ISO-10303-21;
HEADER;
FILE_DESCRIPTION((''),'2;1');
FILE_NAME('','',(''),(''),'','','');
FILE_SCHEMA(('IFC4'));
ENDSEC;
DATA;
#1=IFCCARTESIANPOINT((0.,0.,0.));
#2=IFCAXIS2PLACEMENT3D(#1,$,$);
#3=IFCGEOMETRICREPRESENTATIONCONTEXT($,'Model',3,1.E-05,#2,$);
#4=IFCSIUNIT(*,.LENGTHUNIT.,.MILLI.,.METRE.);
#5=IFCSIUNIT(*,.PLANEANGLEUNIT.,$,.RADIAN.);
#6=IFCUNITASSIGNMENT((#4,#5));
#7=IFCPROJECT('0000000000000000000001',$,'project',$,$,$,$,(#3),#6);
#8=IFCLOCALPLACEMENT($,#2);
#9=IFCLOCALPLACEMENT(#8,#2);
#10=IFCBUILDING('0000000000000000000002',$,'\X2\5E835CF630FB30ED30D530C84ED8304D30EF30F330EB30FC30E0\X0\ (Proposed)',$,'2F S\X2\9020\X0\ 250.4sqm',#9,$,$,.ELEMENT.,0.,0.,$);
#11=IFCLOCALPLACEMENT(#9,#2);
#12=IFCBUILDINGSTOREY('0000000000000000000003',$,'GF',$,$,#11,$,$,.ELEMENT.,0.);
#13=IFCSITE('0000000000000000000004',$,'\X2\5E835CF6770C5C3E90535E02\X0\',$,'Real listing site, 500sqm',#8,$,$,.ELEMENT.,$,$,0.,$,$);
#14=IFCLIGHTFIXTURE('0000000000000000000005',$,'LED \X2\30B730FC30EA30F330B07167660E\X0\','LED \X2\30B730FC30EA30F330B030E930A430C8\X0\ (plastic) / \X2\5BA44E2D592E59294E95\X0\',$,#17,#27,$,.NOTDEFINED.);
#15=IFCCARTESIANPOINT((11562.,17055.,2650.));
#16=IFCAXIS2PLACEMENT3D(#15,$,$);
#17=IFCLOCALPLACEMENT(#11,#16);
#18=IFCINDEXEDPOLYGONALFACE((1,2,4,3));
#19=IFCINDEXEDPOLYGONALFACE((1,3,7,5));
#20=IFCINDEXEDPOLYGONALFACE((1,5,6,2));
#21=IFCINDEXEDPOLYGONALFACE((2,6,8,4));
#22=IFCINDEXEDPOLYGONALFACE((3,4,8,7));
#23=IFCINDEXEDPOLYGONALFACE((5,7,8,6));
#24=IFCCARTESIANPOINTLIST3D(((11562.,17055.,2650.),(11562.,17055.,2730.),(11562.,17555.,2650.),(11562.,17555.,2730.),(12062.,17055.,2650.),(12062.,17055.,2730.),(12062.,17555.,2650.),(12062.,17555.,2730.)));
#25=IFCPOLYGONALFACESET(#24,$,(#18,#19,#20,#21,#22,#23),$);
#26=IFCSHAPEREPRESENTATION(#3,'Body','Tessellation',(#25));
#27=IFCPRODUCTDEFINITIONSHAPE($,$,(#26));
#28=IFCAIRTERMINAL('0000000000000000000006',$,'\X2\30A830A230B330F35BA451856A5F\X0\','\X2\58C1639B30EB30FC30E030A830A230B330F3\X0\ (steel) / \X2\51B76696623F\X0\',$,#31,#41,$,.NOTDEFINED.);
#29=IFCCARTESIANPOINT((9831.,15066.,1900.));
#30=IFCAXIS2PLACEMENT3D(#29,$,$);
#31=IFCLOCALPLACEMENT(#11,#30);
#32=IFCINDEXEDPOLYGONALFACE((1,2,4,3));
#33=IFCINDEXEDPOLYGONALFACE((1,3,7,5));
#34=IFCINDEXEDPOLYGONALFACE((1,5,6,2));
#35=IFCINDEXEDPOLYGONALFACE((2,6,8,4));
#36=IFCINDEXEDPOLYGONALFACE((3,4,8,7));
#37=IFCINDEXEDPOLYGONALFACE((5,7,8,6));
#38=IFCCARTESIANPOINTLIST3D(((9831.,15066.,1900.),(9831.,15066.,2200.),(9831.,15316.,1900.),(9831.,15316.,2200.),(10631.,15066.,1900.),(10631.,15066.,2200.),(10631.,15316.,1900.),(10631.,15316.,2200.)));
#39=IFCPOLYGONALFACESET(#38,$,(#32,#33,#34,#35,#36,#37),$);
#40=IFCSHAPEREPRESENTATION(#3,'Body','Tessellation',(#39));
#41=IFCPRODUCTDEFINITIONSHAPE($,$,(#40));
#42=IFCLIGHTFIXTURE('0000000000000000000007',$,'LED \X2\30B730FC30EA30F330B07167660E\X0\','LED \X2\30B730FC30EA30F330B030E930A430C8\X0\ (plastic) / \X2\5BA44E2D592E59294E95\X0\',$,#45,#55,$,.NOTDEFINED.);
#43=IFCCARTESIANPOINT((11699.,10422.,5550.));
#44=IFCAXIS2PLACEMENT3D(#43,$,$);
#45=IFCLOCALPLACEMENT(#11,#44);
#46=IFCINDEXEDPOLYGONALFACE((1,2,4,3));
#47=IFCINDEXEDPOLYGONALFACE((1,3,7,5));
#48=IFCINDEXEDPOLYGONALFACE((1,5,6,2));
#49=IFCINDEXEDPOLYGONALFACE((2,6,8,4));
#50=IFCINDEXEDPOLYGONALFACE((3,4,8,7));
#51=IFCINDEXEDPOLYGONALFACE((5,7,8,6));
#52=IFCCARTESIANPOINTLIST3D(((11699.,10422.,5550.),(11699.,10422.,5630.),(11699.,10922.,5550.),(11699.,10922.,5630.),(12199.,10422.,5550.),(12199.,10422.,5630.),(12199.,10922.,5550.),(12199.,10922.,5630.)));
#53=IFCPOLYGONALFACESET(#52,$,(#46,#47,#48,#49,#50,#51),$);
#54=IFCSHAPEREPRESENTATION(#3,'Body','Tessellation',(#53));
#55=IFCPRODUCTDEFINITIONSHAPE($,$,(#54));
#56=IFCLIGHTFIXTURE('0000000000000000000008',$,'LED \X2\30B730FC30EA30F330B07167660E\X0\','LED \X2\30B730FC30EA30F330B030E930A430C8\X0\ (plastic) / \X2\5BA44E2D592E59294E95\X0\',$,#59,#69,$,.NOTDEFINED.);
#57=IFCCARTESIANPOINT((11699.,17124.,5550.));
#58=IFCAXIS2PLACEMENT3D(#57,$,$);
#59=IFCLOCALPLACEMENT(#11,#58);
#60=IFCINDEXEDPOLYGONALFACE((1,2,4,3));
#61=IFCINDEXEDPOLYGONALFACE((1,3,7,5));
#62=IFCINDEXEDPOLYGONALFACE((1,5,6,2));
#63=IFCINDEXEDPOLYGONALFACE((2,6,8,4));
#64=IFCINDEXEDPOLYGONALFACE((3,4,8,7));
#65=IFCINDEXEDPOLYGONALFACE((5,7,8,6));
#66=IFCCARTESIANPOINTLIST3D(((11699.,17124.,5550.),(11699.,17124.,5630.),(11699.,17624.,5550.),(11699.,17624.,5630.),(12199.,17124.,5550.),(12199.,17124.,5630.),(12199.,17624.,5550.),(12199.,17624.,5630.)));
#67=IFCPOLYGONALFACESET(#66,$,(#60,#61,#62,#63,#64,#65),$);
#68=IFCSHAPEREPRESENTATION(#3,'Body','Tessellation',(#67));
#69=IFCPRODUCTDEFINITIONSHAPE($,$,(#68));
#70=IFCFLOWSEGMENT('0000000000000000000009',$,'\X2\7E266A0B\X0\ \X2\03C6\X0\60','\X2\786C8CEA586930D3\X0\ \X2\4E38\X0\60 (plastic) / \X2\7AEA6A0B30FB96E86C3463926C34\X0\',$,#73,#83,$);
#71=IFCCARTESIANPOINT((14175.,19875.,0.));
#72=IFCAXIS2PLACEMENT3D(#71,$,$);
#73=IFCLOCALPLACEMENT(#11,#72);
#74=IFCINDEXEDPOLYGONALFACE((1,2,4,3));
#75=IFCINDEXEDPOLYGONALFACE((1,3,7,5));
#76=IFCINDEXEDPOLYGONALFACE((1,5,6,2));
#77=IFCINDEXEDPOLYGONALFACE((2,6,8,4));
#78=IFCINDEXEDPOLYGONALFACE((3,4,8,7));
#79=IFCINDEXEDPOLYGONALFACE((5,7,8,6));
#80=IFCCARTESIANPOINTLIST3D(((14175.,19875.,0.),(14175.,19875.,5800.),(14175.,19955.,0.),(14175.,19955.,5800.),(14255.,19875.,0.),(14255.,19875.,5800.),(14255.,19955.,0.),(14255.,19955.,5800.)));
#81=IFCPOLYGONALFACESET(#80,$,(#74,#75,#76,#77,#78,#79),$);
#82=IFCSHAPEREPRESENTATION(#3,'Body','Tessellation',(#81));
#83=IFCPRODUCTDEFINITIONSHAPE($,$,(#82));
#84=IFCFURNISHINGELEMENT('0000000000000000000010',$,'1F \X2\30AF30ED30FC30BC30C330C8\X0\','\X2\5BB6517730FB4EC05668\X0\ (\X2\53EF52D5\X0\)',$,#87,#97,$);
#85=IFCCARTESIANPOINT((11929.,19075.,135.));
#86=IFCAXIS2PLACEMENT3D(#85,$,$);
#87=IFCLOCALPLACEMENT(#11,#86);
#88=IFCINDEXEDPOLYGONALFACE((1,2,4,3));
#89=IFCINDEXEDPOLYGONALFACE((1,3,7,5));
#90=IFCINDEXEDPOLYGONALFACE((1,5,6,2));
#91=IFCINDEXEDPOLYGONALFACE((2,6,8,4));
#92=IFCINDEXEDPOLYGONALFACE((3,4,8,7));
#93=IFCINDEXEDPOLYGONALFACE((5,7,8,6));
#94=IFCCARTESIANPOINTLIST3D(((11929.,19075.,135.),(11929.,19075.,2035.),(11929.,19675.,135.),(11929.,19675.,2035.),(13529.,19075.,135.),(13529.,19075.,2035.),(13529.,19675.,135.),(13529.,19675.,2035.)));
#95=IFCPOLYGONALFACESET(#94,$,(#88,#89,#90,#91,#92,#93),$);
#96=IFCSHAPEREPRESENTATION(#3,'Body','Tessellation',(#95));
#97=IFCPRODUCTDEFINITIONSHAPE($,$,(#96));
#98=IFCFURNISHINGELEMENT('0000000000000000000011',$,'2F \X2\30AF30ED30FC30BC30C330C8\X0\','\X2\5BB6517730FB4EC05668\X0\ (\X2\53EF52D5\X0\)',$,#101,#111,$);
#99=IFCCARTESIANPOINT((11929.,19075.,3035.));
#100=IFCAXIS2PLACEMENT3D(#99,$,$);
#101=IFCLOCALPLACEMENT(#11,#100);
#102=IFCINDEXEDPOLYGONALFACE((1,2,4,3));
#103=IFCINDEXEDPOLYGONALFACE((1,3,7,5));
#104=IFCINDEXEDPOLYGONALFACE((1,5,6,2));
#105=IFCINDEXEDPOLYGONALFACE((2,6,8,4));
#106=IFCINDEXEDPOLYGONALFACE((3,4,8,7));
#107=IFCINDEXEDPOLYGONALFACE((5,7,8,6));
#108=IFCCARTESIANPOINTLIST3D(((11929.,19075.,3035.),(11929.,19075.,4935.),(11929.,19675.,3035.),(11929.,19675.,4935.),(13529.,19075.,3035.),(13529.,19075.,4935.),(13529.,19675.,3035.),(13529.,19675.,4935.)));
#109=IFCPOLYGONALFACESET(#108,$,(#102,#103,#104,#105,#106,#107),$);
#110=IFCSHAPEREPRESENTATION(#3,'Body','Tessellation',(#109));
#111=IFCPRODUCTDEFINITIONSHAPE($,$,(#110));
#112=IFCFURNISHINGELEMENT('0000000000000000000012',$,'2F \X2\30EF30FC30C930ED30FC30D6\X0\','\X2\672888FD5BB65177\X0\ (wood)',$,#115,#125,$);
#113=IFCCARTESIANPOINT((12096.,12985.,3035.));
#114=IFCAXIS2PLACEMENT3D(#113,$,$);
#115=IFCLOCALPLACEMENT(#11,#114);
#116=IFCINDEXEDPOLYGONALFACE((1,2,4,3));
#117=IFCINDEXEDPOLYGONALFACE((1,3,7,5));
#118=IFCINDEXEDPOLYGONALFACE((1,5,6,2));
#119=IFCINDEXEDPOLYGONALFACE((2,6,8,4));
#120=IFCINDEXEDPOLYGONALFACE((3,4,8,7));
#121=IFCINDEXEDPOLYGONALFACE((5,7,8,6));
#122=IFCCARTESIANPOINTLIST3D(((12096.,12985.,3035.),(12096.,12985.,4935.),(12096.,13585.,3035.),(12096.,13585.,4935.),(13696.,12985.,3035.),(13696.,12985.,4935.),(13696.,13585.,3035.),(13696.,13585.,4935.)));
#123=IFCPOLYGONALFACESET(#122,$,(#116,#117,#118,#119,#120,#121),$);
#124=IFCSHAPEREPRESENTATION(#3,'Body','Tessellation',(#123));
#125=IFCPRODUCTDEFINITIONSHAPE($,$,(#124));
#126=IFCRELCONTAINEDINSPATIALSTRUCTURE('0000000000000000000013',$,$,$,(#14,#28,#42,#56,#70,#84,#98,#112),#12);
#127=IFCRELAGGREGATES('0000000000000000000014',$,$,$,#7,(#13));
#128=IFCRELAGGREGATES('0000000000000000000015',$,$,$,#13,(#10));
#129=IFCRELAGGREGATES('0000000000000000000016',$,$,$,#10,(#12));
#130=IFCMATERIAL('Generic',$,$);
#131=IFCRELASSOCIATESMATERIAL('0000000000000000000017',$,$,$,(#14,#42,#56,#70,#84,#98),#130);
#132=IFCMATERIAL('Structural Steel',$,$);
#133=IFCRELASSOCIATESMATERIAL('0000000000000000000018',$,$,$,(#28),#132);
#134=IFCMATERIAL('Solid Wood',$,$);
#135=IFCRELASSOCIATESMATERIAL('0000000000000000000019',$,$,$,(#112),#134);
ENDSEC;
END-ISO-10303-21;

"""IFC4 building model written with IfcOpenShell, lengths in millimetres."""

from ifc_helpers import new_model, si_unit, frame, frame_2d, origin, place, context, project, spatial, rectangle, extrude, material, element, save


model = new_model("IFC4")

# Units and contexts
model_context = context("Model", 3, precision=1e-05, world=origin())
ifc_project = project(units=[si_unit("LENGTHUNIT", "METRE", prefix="MILLI"), si_unit("PLANEANGLEUNIT", "RADIAN")], contexts=[model_context])

# Site, building, storey
site_placement = place(None, origin())
site = spatial("IfcSite", under=ifc_project, at=site_placement, Name="広島県尾道市", ObjectType="Real listing site, 500sqm", CompositionType="ELEMENT", RefElevation=0.0)
building_placement = place(site_placement, origin())
building = spatial("IfcBuilding", under=site, at=building_placement, Name="広島・ロフト付きワンルーム (Proposed)", ObjectType="2F S造 250.4sqm", CompositionType="ELEMENT", ElevationOfRefHeight=0.0, ElevationOfTerrain=0.0)
storey_placement = place(building_placement, origin())
storey = spatial("IfcBuildingStorey", under=building, at=storey_placement, Name="GF", CompositionType="ELEMENT", Elevation=0.0)

# Shared definitions
ifc_material_1 = material(Name="Solid Wood")

# Shared definitions
ifc_material_2 = material(Name="Structural Steel")

# Shared definitions
ifc_material_3 = material(Name="Generic")

# Light fixture
light_fixture_1_placement = place(storey_placement, frame((11562.0, 17055.0, 2650.0)))
element("IfcLightFixture", 1, at=light_fixture_1_placement, inside=storey, material=ifc_material_3, Name="LED シーリング照明", Description="LED シーリングライト (plastic) / 室中央天井", PredefinedType="NOTDEFINED", context=model_context, shape_type="SweptSolid", body=[
    extrude(rectangle(XDim=500.0, YDim=500.0, at=frame_2d((250.0, 250.0))), frame((11562.0, 17055.0, 2650.0)), (0.0, 0.0, 1.0), 80.0),
])

# Air terminal
air_terminal_placement = place(storey_placement, frame((9831.0, 15066.0, 1900.0)))
element("IfcAirTerminal", 2, at=air_terminal_placement, inside=storey, material=ifc_material_2, Name="エアコン室内機", Description="壁掛ルームエアコン (steel) / 冷暖房", PredefinedType="NOTDEFINED", context=model_context, shape_type="SweptSolid", body=[
    extrude(rectangle(XDim=800.0, YDim=250.0, at=frame_2d((400.0, 125.0))), frame((9831.0, 15066.0, 1900.0)), (0.0, 0.0, 1.0), 300.0),
])

# Light fixtures
light_fixture_2_placement = place(storey_placement, frame((11699.0, 10422.0, 5550.0)))
element("IfcLightFixture", 3, at=light_fixture_2_placement, inside=storey, material=ifc_material_3, Name="LED シーリング照明", Description="LED シーリングライト (plastic) / 室中央天井", PredefinedType="NOTDEFINED", context=model_context, shape_type="SweptSolid", body=[
    extrude(rectangle(XDim=500.0, YDim=500.0, at=frame_2d((250.0, 250.0))), frame((11699.0, 10422.0, 5550.0)), (0.0, 0.0, 1.0), 80.0),
])
light_fixture_3_placement = place(storey_placement, frame((11699.0, 17124.0, 5550.0)))
element("IfcLightFixture", 4, at=light_fixture_3_placement, inside=storey, material=ifc_material_3, Name="LED シーリング照明", Description="LED シーリングライト (plastic) / 室中央天井", PredefinedType="NOTDEFINED", context=model_context, shape_type="SweptSolid", body=[
    extrude(rectangle(XDim=500.0, YDim=500.0, at=frame_2d((250.0, 250.0))), frame((11699.0, 17124.0, 5550.0)), (0.0, 0.0, 1.0), 80.0),
])

# Flow segment
flow_segment_placement = place(storey_placement, frame((14175.0, 19875.0, 0.0)))
element("IfcFlowSegment", 5, at=flow_segment_placement, inside=storey, material=ifc_material_3, Name="縦樋 φ60", Description="硬質塩ビ 丸60 (plastic) / 竪樋・雨水排水", context=model_context, shape_type="SweptSolid", body=[
    extrude(rectangle(XDim=80.0, YDim=80.0, at=frame_2d((40.0, 40.0))), frame((14175.0, 19875.0, 0.0)), (0.0, 0.0, 1.0), 5800.0),
])

# Furnishing elements
furnishing_1_placement = place(storey_placement, frame((11929.0, 19075.0, 135.0)))
element("IfcFurnishingElement", 6, at=furnishing_1_placement, inside=storey, material=ifc_material_3, Name="1F クローゼット", Description="家具・什器 (可動)", context=model_context, shape_type="SweptSolid", body=[
    extrude(rectangle(XDim=1600.0, YDim=600.0, at=frame_2d((800.0, 300.0))), frame((11929.0, 19075.0, 135.0)), (0.0, 0.0, 1.0), 1900.0),
])
furnishing_2_placement = place(storey_placement, frame((11929.0, 19075.0, 3035.0)))
element("IfcFurnishingElement", 7, at=furnishing_2_placement, inside=storey, material=ifc_material_3, Name="2F クローゼット", Description="家具・什器 (可動)", context=model_context, shape_type="SweptSolid", body=[
    extrude(rectangle(XDim=1600.0, YDim=600.0, at=frame_2d((800.0, 300.0))), frame((11929.0, 19075.0, 3035.0)), (0.0, 0.0, 1.0), 1900.0),
])
furnishing_3_placement = place(storey_placement, frame((12096.0, 12985.0, 3035.0)))
element("IfcFurnishingElement", 8, at=furnishing_3_placement, inside=storey, material=ifc_material_1, Name="2F ワードローブ", Description="木製家具 (wood)", context=model_context, shape_type="SweptSolid", body=[
    extrude(rectangle(XDim=1600.0, YDim=600.0, at=frame_2d((800.0, 300.0))), frame((12096.0, 12985.0, 3035.0)), (0.0, 0.0, 1.0), 1900.0),
])

save(model, "model.ifc")
